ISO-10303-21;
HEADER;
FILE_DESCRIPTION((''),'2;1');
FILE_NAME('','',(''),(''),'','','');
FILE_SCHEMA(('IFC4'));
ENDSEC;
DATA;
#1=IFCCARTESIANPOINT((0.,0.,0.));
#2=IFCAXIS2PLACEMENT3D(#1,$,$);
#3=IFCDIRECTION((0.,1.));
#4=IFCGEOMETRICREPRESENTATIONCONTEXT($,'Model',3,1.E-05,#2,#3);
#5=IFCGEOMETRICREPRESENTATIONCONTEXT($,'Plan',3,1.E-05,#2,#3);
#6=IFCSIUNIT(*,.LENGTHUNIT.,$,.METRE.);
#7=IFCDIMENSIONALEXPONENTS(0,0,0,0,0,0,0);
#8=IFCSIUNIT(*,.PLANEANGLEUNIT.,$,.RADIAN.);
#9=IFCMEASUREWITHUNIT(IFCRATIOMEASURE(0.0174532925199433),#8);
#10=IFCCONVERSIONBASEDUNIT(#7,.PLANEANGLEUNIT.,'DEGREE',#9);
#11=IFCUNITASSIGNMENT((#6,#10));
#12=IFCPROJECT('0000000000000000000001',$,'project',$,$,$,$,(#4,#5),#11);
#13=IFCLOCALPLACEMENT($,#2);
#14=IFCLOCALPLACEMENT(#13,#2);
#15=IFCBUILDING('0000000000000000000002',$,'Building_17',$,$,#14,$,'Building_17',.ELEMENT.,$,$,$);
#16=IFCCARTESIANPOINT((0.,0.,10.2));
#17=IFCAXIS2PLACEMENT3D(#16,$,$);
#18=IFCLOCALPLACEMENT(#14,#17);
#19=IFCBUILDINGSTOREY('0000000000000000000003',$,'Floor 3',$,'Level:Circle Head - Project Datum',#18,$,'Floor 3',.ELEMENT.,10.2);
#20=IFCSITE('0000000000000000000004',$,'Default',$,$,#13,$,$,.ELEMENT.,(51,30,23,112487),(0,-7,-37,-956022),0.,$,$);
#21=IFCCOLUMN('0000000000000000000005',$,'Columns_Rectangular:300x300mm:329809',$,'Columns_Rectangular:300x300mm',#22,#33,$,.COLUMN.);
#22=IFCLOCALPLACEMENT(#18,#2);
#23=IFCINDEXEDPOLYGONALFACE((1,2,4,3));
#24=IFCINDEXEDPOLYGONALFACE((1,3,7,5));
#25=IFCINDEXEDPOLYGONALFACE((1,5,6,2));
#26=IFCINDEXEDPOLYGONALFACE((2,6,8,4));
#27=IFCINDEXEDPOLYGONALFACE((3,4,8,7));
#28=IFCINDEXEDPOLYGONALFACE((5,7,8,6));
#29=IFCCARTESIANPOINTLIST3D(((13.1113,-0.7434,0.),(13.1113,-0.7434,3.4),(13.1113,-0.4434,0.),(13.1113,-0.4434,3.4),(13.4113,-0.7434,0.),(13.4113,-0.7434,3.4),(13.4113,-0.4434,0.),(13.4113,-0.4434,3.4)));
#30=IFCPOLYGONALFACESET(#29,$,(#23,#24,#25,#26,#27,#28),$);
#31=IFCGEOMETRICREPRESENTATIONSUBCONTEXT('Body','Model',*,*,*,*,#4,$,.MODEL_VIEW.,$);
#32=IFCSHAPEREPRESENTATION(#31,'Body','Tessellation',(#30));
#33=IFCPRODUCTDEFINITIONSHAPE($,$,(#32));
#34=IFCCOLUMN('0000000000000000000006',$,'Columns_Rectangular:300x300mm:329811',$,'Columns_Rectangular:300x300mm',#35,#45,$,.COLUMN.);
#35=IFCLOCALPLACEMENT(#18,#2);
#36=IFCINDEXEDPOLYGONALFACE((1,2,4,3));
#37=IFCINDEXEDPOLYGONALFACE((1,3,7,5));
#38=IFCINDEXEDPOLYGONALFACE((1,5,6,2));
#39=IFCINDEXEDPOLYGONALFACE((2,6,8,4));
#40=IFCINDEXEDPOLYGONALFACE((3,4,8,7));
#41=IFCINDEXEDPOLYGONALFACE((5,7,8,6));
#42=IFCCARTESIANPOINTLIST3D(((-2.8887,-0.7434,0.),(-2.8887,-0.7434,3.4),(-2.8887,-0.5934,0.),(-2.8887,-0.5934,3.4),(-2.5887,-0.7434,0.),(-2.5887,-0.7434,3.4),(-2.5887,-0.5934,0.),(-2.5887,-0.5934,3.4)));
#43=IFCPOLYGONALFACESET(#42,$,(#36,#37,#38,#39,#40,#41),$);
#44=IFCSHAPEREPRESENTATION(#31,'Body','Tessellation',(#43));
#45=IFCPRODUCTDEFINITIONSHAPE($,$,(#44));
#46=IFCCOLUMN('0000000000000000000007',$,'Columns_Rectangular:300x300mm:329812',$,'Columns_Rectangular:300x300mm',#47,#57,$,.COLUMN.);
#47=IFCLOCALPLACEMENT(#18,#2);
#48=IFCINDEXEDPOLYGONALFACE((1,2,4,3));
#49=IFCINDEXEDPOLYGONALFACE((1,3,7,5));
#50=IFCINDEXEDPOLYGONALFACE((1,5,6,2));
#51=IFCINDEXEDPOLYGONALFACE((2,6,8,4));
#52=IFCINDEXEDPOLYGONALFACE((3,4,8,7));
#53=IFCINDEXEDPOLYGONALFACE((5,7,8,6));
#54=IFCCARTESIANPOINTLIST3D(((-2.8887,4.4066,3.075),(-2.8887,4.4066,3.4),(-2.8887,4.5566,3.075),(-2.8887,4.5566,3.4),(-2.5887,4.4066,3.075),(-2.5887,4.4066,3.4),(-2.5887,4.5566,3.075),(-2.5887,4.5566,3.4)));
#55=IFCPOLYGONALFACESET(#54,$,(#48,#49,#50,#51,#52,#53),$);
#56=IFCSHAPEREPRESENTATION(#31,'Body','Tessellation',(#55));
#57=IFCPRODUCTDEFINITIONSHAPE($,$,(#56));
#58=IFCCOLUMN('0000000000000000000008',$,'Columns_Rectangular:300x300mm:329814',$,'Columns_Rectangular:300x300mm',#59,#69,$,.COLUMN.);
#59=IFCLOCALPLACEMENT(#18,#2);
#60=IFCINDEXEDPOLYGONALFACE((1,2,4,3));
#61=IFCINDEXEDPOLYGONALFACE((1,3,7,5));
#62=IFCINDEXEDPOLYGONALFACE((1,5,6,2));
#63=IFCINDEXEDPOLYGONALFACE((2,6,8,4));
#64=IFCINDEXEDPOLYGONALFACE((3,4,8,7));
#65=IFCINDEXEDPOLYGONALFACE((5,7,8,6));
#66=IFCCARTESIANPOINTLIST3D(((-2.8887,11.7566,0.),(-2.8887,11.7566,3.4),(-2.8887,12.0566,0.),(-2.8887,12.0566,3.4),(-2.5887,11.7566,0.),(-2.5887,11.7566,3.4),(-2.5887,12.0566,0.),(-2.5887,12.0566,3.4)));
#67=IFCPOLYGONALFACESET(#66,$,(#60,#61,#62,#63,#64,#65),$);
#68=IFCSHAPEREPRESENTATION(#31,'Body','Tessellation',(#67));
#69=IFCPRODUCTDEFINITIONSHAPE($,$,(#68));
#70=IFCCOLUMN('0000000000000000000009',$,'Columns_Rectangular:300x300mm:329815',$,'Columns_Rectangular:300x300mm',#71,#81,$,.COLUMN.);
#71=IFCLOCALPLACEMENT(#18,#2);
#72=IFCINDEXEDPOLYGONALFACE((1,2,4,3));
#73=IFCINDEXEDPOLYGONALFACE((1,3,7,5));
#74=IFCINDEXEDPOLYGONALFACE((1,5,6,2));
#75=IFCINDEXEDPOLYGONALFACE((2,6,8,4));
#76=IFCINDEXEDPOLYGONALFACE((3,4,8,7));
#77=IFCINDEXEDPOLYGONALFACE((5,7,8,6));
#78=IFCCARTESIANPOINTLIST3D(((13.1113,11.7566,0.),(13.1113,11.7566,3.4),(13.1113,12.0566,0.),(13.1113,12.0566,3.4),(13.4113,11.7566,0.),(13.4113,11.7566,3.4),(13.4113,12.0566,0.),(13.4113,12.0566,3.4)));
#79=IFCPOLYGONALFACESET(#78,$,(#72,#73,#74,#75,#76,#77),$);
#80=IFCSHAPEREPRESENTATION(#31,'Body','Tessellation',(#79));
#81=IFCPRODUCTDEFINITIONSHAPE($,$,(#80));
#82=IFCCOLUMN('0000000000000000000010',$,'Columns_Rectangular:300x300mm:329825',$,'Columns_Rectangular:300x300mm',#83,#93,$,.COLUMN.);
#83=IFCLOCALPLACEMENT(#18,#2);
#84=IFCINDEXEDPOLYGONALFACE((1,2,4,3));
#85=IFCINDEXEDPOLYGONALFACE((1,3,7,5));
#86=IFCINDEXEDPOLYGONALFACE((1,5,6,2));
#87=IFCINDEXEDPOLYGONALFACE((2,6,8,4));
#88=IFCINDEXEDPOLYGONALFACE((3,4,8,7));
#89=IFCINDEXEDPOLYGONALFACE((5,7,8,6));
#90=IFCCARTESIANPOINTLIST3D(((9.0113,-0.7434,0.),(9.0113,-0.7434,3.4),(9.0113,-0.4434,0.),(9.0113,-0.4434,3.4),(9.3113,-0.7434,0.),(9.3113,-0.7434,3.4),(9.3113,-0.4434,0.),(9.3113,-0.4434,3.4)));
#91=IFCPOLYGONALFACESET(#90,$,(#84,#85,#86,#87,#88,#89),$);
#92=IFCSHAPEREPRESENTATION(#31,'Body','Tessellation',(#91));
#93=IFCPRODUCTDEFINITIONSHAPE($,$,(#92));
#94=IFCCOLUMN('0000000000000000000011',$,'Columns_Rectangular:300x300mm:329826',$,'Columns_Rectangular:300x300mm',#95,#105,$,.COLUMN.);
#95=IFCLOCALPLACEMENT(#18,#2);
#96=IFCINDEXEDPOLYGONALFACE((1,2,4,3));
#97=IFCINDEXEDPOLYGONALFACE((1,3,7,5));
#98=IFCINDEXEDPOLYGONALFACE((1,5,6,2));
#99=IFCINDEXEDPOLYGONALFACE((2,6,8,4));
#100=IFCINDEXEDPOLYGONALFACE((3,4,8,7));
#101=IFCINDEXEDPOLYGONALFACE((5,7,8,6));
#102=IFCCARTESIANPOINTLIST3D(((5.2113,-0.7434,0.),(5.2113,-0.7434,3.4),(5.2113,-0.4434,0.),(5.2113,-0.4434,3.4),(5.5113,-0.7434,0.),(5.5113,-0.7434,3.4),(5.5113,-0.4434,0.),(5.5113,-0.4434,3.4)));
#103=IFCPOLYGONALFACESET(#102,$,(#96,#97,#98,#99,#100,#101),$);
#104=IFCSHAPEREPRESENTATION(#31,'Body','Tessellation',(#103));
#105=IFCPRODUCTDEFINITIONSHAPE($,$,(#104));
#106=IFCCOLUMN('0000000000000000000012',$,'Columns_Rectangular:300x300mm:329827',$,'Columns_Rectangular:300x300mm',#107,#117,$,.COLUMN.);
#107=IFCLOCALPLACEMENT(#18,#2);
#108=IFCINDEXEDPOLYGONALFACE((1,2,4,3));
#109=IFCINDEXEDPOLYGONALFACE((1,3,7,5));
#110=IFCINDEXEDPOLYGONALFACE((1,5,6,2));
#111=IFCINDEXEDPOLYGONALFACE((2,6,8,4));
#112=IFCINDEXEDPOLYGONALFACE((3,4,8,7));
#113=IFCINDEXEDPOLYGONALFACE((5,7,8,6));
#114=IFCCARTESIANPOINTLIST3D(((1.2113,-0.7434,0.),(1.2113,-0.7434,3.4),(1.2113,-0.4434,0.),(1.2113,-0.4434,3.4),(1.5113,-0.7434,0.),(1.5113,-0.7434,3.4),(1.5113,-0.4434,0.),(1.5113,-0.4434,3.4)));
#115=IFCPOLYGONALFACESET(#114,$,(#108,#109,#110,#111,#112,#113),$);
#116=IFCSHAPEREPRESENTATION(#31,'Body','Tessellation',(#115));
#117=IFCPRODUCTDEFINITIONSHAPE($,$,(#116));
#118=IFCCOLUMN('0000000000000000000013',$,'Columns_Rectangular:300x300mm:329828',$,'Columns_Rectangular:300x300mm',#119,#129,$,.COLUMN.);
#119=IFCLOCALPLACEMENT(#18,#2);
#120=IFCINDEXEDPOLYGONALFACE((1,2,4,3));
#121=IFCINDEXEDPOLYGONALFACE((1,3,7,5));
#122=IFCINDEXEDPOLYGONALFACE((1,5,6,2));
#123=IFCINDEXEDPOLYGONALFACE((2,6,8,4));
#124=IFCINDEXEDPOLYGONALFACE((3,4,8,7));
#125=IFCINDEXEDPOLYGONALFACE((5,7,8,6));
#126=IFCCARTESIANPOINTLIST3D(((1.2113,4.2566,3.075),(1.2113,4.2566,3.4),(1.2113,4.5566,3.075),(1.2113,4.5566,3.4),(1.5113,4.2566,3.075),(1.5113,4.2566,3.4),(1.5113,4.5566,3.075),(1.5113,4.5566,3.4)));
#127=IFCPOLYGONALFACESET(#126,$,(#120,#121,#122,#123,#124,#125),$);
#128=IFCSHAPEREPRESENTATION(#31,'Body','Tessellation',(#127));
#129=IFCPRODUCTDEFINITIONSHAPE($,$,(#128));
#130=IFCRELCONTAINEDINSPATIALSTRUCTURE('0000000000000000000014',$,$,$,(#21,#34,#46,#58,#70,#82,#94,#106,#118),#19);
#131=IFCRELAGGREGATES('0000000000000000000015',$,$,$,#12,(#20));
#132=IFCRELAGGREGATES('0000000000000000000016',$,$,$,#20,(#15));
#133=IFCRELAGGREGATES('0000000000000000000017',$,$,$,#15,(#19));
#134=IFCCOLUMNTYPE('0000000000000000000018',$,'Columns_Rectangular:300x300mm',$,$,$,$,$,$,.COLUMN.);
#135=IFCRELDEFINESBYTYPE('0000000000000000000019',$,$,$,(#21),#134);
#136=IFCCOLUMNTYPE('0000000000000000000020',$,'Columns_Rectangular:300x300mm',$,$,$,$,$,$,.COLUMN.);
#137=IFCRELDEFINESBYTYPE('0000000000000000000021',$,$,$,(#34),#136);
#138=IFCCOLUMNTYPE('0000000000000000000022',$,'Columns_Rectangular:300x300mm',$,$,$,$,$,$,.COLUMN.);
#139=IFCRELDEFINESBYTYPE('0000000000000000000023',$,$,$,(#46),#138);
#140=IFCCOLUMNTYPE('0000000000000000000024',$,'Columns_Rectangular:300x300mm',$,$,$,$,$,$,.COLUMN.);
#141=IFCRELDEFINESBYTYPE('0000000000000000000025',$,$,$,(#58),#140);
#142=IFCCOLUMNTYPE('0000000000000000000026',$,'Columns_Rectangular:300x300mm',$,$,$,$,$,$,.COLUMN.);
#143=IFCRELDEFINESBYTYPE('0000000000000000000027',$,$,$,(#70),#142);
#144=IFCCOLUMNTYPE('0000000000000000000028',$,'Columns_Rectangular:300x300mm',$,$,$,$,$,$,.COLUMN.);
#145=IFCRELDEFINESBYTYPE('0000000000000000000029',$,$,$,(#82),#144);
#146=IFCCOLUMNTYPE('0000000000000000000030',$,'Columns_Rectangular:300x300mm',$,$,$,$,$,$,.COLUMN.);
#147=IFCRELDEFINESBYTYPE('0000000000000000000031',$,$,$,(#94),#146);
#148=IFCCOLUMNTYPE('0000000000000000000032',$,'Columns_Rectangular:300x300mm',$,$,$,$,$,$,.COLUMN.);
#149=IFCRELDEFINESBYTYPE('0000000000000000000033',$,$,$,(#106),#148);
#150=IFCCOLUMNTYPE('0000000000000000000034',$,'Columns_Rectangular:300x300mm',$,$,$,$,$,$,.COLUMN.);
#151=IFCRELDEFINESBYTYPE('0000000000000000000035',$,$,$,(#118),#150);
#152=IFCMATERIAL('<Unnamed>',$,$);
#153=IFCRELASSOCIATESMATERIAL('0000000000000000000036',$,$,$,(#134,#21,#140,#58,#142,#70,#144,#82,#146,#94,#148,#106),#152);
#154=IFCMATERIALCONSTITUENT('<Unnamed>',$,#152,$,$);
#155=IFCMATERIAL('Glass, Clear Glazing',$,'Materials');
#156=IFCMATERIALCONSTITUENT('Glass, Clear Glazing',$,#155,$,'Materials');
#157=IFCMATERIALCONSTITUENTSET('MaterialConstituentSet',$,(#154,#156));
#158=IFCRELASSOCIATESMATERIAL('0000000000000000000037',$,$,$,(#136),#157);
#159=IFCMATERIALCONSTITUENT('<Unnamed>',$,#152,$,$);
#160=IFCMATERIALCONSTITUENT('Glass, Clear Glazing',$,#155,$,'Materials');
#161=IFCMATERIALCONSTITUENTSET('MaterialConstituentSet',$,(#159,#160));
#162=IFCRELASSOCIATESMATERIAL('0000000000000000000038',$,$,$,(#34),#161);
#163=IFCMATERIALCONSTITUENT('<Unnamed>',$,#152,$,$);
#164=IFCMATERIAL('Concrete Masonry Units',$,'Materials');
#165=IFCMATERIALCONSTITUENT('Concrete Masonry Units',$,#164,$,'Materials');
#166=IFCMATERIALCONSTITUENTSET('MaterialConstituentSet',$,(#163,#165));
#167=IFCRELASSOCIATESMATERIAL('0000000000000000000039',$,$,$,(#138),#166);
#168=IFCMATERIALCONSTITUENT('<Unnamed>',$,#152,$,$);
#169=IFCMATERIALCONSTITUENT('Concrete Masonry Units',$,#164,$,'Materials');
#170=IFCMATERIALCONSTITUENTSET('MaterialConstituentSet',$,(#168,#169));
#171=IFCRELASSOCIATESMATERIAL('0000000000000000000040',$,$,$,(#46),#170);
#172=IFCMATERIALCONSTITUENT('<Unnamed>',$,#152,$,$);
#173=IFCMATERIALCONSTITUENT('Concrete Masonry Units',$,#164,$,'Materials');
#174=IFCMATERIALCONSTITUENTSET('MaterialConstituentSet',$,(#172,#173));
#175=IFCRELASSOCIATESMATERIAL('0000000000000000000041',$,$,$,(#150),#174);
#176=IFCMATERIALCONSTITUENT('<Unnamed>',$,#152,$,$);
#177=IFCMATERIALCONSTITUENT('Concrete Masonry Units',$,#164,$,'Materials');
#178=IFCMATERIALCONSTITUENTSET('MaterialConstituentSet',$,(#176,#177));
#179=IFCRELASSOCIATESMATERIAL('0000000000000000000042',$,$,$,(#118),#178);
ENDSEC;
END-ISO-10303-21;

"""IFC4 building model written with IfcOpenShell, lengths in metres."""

from ifc_helpers import new_model, entity, si_unit, converted_unit, direction, frame, origin, place, context, subcontext, project, spatial, indexed_curve, outline, extrude, source, transform, mapped, material, constituent, constituent_set, type_object, type_shapes, element, save


model = new_model("IFC4")

# Units and contexts
model_context = context("Model", 3, precision=1e-05, world=origin(), true_north=direction((0.0, 1.0)))
plan_context = context("Plan", 3, precision=1e-05, world=origin(), true_north=direction((0.0, 1.0)))
body_context = subcontext(model_context, "Body", "Model", "MODEL_VIEW")
ifc_project = project(units=[si_unit("LENGTHUNIT", "METRE"), converted_unit("PLANEANGLEUNIT", "DEGREE", entity("IfcRatioMeasure", 0.0174532925199433), si_unit("PLANEANGLEUNIT", "RADIAN"), dimensions=[0, 0, 0, 0, 0, 0, 0])], contexts=[model_context, plan_context])

# Site, building, storey
site_placement = place(None, origin())
site = spatial("IfcSite", under=ifc_project, at=site_placement, Name="Default", CompositionType="ELEMENT", RefLatitude=(51, 30, 23, 112487), RefLongitude=(0, -7, -37, -956022), RefElevation=0.0)
building_placement = place(site_placement, origin())
building = spatial("IfcBuilding", under=site, at=building_placement, Name="Building_17", LongName="Building_17", CompositionType="ELEMENT")
storey_placement = place(building_placement, frame((0.0, 0.0, 10.2)))
storey = spatial("IfcBuildingStorey", under=building, at=storey_placement, Name="Floor 3", ObjectType="Level:Circle Head - Project Datum", LongName="Floor 3", CompositionType="ELEMENT", Elevation=10.2)

# Columns
ifc_material_1 = material(Name="<Unnamed>")
column_type_1 = type_object("IfcColumnType", Name="Columns_Rectangular:300x300mm", PredefinedType="COLUMN", material=ifc_material_1)
shared_shape_1 = source(origin(), body_context, "Body", "SweptSolid", [
    extrude(outline(indexed_curve([(-0.15, -0.15), (0.15, -0.15), (0.15, 0.15), (-0.15, 0.15), (-0.15, -0.15)], self_intersect=False)), frame((13.2613, -0.5934, 10.2), z_axis=(0.0, 0.0, 1.0), x_axis=(0.0, -1.0, 0.0)), (0.0, 0.0, 1.0), 3.4),
])
type_shapes(column_type_1, [shared_shape_1])
column_1_placement = place(storey_placement, frame((0.0, 0.0, -10.2)))
element("IfcColumn", 1, at=column_1_placement, inside=storey, type_object=column_type_1, material=ifc_material_1, Name="Columns_Rectangular:300x300mm:329809", ObjectType="Columns_Rectangular:300x300mm", PredefinedType="COLUMN", context=body_context, shape_type="MappedRepresentation", body=[
    mapped(shared_shape_1, transform((0.0, 0.0, 0.0), scale=1.0)),
])
ifc_constituent_1 = constituent(ifc_material_1, Name="<Unnamed>")
ifc_material_2 = material(Name="Glass, Clear Glazing", Category="Materials")
ifc_constituent_2 = constituent(ifc_material_2, Name="Glass, Clear Glazing", Category="Materials")
ifc_constituent_set_1 = constituent_set(constituents=[ifc_constituent_1, ifc_constituent_2], Name="MaterialConstituentSet")
ifc_constituent_3 = constituent(ifc_material_1, Name="<Unnamed>")
ifc_constituent_4 = constituent(ifc_material_2, Name="Glass, Clear Glazing", Category="Materials")
ifc_constituent_set_2 = constituent_set(constituents=[ifc_constituent_3, ifc_constituent_4], Name="MaterialConstituentSet")
column_type_2 = type_object("IfcColumnType", Name="Columns_Rectangular:300x300mm", PredefinedType="COLUMN", material=ifc_constituent_set_2)
shared_shape_2 = source(origin(), body_context, "Body", "SweptSolid", [
    extrude(outline(indexed_curve([(-0.075, -0.15), (0.075, -0.15), (0.075, 0.15), (-0.075, 0.15), (-0.075, -0.15)], self_intersect=False)), frame((-2.7387, -0.6684, 10.2), z_axis=(0.0, 0.0, 1.0), x_axis=(0.0, -1.0, 0.0)), (0.0, 0.0, 1.0), 3.4),
])
type_shapes(column_type_2, [shared_shape_2])
column_2_placement = place(storey_placement, frame((0.0, 0.0, -10.2)))
element("IfcColumn", 2, at=column_2_placement, inside=storey, type_object=column_type_2, material=ifc_constituent_set_1, Name="Columns_Rectangular:300x300mm:329811", ObjectType="Columns_Rectangular:300x300mm", PredefinedType="COLUMN", context=body_context, shape_type="MappedRepresentation", body=[
    mapped(shared_shape_2, transform((0.0, 0.0, 0.0), scale=1.0)),
])
ifc_constituent_5 = constituent(ifc_material_1, Name="<Unnamed>")
ifc_material_3 = material(Name="Concrete Masonry Units", Category="Materials")
ifc_constituent_6 = constituent(ifc_material_3, Name="Concrete Masonry Units", Category="Materials")
ifc_constituent_set_3 = constituent_set(constituents=[ifc_constituent_5, ifc_constituent_6], Name="MaterialConstituentSet")
ifc_constituent_7 = constituent(ifc_material_1, Name="<Unnamed>")
ifc_constituent_8 = constituent(ifc_material_3, Name="Concrete Masonry Units", Category="Materials")
ifc_constituent_set_4 = constituent_set(constituents=[ifc_constituent_7, ifc_constituent_8], Name="MaterialConstituentSet")
column_type_3 = type_object("IfcColumnType", Name="Columns_Rectangular:300x300mm", PredefinedType="COLUMN", material=ifc_constituent_set_4)
shared_shape_3 = source(origin(), body_context, "Body", "SweptSolid", [
    extrude(outline(indexed_curve([(-0.075, -0.15), (0.075, -0.15), (0.075, 0.15), (-0.075, 0.15), (-0.075, -0.15)], self_intersect=False)), frame((-2.7387, 4.4816, 13.275), z_axis=(0.0, 0.0, 1.0), x_axis=(0.0, -1.0, 0.0)), (0.0, 0.0, 1.0), 0.325),
])
type_shapes(column_type_3, [shared_shape_3])
column_3_placement = place(storey_placement, frame((0.0, 0.0, -10.2)))
element("IfcColumn", 3, at=column_3_placement, inside=storey, type_object=column_type_3, material=ifc_constituent_set_3, Name="Columns_Rectangular:300x300mm:329812", ObjectType="Columns_Rectangular:300x300mm", PredefinedType="COLUMN", context=body_context, shape_type="MappedRepresentation", body=[
    mapped(shared_shape_3, transform((0.0, 0.0, 0.0), scale=1.0)),
])
column_type_4 = type_object("IfcColumnType", Name="Columns_Rectangular:300x300mm", PredefinedType="COLUMN", material=ifc_material_1)
shared_shape_4 = source(origin(), body_context, "Body", "SweptSolid", [
    extrude(outline(indexed_curve([(-0.15, -0.15), (0.15, -0.15), (0.15, 0.15), (-0.15, 0.15), (-0.15, -0.15)], self_intersect=False)), frame((-2.7387, 11.9066, 10.2), z_axis=(0.0, 0.0, 1.0), x_axis=(0.0, -1.0, 0.0)), (0.0, 0.0, 1.0), 3.4),
])
type_shapes(column_type_4, [shared_shape_4])
column_4_placement = place(storey_placement, frame((0.0, 0.0, -10.2)))
element("IfcColumn", 4, at=column_4_placement, inside=storey, type_object=column_type_4, material=ifc_material_1, Name="Columns_Rectangular:300x300mm:329814", ObjectType="Columns_Rectangular:300x300mm", PredefinedType="COLUMN", context=body_context, shape_type="MappedRepresentation", body=[
    mapped(shared_shape_4, transform((0.0, 0.0, 0.0), scale=1.0)),
])
column_type_5 = type_object("IfcColumnType", Name="Columns_Rectangular:300x300mm", PredefinedType="COLUMN", material=ifc_material_1)
shared_shape_5 = source(origin(), body_context, "Body", "SweptSolid", [
    extrude(outline(indexed_curve([(-0.15, -0.15), (0.15, -0.15), (0.15, 0.15), (-0.15, 0.15), (-0.15, -0.15)], self_intersect=False)), frame((13.2613, 11.9066, 10.2), z_axis=(0.0, 0.0, 1.0), x_axis=(0.0, -1.0, 0.0)), (0.0, 0.0, 1.0), 3.4),
])
type_shapes(column_type_5, [shared_shape_5])
column_5_placement = place(storey_placement, frame((0.0, 0.0, -10.2)))
element("IfcColumn", 5, at=column_5_placement, inside=storey, type_object=column_type_5, material=ifc_material_1, Name="Columns_Rectangular:300x300mm:329815", ObjectType="Columns_Rectangular:300x300mm", PredefinedType="COLUMN", context=body_context, shape_type="MappedRepresentation", body=[
    mapped(shared_shape_5, transform((0.0, 0.0, 0.0), scale=1.0)),
])
column_type_6 = type_object("IfcColumnType", Name="Columns_Rectangular:300x300mm", PredefinedType="COLUMN", material=ifc_material_1)
shared_shape_6 = source(origin(), body_context, "Body", "SweptSolid", [
    extrude(outline(indexed_curve([(-0.15, -0.15), (0.15, -0.15), (0.15, 0.15), (-0.15, 0.15), (-0.15, -0.15)], self_intersect=False)), frame((9.1613, -0.5934, 10.2), z_axis=(0.0, 0.0, 1.0), x_axis=(0.0, -1.0, 0.0)), (0.0, 0.0, 1.0), 3.4),
])
type_shapes(column_type_6, [shared_shape_6])
column_6_placement = place(storey_placement, frame((0.0, 0.0, -10.2)))
element("IfcColumn", 6, at=column_6_placement, inside=storey, type_object=column_type_6, material=ifc_material_1, Name="Columns_Rectangular:300x300mm:329825", ObjectType="Columns_Rectangular:300x300mm", PredefinedType="COLUMN", context=body_context, shape_type="MappedRepresentation", body=[
    mapped(shared_shape_6, transform((0.0, 0.0, 0.0), scale=1.0)),
])
column_type_7 = type_object("IfcColumnType", Name="Columns_Rectangular:300x300mm", PredefinedType="COLUMN", material=ifc_material_1)
shared_shape_7 = source(origin(), body_context, "Body", "SweptSolid", [
    extrude(outline(indexed_curve([(-0.15, -0.15), (0.15, -0.15), (0.15, 0.15), (-0.15, 0.15), (-0.15, -0.15)], self_intersect=False)), frame((5.3613, -0.5934, 10.2), z_axis=(0.0, 0.0, 1.0), x_axis=(0.0, -1.0, 0.0)), (0.0, 0.0, 1.0), 3.4),
])
type_shapes(column_type_7, [shared_shape_7])
column_7_placement = place(storey_placement, frame((0.0, 0.0, -10.2)))
element("IfcColumn", 7, at=column_7_placement, inside=storey, type_object=column_type_7, material=ifc_material_1, Name="Columns_Rectangular:300x300mm:329826", ObjectType="Columns_Rectangular:300x300mm", PredefinedType="COLUMN", context=body_context, shape_type="MappedRepresentation", body=[
    mapped(shared_shape_7, transform((0.0, 0.0, 0.0), scale=1.0)),
])
column_type_8 = type_object("IfcColumnType", Name="Columns_Rectangular:300x300mm", PredefinedType="COLUMN", material=ifc_material_1)
shared_shape_8 = source(origin(), body_context, "Body", "SweptSolid", [
    extrude(outline(indexed_curve([(-0.15, -0.15), (0.15, -0.15), (0.15, 0.15), (-0.15, 0.15), (-0.15, -0.15)], self_intersect=False)), frame((1.3613, -0.5934, 10.2), z_axis=(0.0, 0.0, 1.0), x_axis=(0.0, -1.0, 0.0)), (0.0, 0.0, 1.0), 3.4),
])
type_shapes(column_type_8, [shared_shape_8])
column_8_placement = place(storey_placement, frame((0.0, 0.0, -10.2)))
element("IfcColumn", 8, at=column_8_placement, inside=storey, type_object=column_type_8, material=ifc_material_1, Name="Columns_Rectangular:300x300mm:329827", ObjectType="Columns_Rectangular:300x300mm", PredefinedType="COLUMN", context=body_context, shape_type="MappedRepresentation", body=[
    mapped(shared_shape_8, transform((0.0, 0.0, 0.0), scale=1.0)),
])
ifc_constituent_9 = constituent(ifc_material_1, Name="<Unnamed>")
ifc_constituent_10 = constituent(ifc_material_3, Name="Concrete Masonry Units", Category="Materials")
ifc_constituent_set_5 = constituent_set(constituents=[ifc_constituent_9, ifc_constituent_10], Name="MaterialConstituentSet")
ifc_constituent_11 = constituent(ifc_material_1, Name="<Unnamed>")
ifc_constituent_12 = constituent(ifc_material_3, Name="Concrete Masonry Units", Category="Materials")
ifc_constituent_set_6 = constituent_set(constituents=[ifc_constituent_11, ifc_constituent_12], Name="MaterialConstituentSet")
column_type_9 = type_object("IfcColumnType", Name="Columns_Rectangular:300x300mm", PredefinedType="COLUMN", material=ifc_constituent_set_6)
shared_shape_9 = source(origin(), body_context, "Body", "SweptSolid", [
    extrude(outline(indexed_curve([(-0.15, -0.15), (0.15, -0.15), (0.15, 0.15), (-0.15, 0.15), (-0.15, -0.15)], self_intersect=False)), frame((1.3613, 4.4066, 13.275), z_axis=(0.0, 0.0, 1.0), x_axis=(0.0, -1.0, 0.0)), (0.0, 0.0, 1.0), 0.325),
])
type_shapes(column_type_9, [shared_shape_9])
column_9_placement = place(storey_placement, frame((0.0, 0.0, -10.2)))
element("IfcColumn", 9, at=column_9_placement, inside=storey, type_object=column_type_9, material=ifc_constituent_set_5, Name="Columns_Rectangular:300x300mm:329828", ObjectType="Columns_Rectangular:300x300mm", PredefinedType="COLUMN", context=body_context, shape_type="MappedRepresentation", body=[
    mapped(shared_shape_9, transform((0.0, 0.0, 0.0), scale=1.0)),
])

save(model, "model.ifc")
